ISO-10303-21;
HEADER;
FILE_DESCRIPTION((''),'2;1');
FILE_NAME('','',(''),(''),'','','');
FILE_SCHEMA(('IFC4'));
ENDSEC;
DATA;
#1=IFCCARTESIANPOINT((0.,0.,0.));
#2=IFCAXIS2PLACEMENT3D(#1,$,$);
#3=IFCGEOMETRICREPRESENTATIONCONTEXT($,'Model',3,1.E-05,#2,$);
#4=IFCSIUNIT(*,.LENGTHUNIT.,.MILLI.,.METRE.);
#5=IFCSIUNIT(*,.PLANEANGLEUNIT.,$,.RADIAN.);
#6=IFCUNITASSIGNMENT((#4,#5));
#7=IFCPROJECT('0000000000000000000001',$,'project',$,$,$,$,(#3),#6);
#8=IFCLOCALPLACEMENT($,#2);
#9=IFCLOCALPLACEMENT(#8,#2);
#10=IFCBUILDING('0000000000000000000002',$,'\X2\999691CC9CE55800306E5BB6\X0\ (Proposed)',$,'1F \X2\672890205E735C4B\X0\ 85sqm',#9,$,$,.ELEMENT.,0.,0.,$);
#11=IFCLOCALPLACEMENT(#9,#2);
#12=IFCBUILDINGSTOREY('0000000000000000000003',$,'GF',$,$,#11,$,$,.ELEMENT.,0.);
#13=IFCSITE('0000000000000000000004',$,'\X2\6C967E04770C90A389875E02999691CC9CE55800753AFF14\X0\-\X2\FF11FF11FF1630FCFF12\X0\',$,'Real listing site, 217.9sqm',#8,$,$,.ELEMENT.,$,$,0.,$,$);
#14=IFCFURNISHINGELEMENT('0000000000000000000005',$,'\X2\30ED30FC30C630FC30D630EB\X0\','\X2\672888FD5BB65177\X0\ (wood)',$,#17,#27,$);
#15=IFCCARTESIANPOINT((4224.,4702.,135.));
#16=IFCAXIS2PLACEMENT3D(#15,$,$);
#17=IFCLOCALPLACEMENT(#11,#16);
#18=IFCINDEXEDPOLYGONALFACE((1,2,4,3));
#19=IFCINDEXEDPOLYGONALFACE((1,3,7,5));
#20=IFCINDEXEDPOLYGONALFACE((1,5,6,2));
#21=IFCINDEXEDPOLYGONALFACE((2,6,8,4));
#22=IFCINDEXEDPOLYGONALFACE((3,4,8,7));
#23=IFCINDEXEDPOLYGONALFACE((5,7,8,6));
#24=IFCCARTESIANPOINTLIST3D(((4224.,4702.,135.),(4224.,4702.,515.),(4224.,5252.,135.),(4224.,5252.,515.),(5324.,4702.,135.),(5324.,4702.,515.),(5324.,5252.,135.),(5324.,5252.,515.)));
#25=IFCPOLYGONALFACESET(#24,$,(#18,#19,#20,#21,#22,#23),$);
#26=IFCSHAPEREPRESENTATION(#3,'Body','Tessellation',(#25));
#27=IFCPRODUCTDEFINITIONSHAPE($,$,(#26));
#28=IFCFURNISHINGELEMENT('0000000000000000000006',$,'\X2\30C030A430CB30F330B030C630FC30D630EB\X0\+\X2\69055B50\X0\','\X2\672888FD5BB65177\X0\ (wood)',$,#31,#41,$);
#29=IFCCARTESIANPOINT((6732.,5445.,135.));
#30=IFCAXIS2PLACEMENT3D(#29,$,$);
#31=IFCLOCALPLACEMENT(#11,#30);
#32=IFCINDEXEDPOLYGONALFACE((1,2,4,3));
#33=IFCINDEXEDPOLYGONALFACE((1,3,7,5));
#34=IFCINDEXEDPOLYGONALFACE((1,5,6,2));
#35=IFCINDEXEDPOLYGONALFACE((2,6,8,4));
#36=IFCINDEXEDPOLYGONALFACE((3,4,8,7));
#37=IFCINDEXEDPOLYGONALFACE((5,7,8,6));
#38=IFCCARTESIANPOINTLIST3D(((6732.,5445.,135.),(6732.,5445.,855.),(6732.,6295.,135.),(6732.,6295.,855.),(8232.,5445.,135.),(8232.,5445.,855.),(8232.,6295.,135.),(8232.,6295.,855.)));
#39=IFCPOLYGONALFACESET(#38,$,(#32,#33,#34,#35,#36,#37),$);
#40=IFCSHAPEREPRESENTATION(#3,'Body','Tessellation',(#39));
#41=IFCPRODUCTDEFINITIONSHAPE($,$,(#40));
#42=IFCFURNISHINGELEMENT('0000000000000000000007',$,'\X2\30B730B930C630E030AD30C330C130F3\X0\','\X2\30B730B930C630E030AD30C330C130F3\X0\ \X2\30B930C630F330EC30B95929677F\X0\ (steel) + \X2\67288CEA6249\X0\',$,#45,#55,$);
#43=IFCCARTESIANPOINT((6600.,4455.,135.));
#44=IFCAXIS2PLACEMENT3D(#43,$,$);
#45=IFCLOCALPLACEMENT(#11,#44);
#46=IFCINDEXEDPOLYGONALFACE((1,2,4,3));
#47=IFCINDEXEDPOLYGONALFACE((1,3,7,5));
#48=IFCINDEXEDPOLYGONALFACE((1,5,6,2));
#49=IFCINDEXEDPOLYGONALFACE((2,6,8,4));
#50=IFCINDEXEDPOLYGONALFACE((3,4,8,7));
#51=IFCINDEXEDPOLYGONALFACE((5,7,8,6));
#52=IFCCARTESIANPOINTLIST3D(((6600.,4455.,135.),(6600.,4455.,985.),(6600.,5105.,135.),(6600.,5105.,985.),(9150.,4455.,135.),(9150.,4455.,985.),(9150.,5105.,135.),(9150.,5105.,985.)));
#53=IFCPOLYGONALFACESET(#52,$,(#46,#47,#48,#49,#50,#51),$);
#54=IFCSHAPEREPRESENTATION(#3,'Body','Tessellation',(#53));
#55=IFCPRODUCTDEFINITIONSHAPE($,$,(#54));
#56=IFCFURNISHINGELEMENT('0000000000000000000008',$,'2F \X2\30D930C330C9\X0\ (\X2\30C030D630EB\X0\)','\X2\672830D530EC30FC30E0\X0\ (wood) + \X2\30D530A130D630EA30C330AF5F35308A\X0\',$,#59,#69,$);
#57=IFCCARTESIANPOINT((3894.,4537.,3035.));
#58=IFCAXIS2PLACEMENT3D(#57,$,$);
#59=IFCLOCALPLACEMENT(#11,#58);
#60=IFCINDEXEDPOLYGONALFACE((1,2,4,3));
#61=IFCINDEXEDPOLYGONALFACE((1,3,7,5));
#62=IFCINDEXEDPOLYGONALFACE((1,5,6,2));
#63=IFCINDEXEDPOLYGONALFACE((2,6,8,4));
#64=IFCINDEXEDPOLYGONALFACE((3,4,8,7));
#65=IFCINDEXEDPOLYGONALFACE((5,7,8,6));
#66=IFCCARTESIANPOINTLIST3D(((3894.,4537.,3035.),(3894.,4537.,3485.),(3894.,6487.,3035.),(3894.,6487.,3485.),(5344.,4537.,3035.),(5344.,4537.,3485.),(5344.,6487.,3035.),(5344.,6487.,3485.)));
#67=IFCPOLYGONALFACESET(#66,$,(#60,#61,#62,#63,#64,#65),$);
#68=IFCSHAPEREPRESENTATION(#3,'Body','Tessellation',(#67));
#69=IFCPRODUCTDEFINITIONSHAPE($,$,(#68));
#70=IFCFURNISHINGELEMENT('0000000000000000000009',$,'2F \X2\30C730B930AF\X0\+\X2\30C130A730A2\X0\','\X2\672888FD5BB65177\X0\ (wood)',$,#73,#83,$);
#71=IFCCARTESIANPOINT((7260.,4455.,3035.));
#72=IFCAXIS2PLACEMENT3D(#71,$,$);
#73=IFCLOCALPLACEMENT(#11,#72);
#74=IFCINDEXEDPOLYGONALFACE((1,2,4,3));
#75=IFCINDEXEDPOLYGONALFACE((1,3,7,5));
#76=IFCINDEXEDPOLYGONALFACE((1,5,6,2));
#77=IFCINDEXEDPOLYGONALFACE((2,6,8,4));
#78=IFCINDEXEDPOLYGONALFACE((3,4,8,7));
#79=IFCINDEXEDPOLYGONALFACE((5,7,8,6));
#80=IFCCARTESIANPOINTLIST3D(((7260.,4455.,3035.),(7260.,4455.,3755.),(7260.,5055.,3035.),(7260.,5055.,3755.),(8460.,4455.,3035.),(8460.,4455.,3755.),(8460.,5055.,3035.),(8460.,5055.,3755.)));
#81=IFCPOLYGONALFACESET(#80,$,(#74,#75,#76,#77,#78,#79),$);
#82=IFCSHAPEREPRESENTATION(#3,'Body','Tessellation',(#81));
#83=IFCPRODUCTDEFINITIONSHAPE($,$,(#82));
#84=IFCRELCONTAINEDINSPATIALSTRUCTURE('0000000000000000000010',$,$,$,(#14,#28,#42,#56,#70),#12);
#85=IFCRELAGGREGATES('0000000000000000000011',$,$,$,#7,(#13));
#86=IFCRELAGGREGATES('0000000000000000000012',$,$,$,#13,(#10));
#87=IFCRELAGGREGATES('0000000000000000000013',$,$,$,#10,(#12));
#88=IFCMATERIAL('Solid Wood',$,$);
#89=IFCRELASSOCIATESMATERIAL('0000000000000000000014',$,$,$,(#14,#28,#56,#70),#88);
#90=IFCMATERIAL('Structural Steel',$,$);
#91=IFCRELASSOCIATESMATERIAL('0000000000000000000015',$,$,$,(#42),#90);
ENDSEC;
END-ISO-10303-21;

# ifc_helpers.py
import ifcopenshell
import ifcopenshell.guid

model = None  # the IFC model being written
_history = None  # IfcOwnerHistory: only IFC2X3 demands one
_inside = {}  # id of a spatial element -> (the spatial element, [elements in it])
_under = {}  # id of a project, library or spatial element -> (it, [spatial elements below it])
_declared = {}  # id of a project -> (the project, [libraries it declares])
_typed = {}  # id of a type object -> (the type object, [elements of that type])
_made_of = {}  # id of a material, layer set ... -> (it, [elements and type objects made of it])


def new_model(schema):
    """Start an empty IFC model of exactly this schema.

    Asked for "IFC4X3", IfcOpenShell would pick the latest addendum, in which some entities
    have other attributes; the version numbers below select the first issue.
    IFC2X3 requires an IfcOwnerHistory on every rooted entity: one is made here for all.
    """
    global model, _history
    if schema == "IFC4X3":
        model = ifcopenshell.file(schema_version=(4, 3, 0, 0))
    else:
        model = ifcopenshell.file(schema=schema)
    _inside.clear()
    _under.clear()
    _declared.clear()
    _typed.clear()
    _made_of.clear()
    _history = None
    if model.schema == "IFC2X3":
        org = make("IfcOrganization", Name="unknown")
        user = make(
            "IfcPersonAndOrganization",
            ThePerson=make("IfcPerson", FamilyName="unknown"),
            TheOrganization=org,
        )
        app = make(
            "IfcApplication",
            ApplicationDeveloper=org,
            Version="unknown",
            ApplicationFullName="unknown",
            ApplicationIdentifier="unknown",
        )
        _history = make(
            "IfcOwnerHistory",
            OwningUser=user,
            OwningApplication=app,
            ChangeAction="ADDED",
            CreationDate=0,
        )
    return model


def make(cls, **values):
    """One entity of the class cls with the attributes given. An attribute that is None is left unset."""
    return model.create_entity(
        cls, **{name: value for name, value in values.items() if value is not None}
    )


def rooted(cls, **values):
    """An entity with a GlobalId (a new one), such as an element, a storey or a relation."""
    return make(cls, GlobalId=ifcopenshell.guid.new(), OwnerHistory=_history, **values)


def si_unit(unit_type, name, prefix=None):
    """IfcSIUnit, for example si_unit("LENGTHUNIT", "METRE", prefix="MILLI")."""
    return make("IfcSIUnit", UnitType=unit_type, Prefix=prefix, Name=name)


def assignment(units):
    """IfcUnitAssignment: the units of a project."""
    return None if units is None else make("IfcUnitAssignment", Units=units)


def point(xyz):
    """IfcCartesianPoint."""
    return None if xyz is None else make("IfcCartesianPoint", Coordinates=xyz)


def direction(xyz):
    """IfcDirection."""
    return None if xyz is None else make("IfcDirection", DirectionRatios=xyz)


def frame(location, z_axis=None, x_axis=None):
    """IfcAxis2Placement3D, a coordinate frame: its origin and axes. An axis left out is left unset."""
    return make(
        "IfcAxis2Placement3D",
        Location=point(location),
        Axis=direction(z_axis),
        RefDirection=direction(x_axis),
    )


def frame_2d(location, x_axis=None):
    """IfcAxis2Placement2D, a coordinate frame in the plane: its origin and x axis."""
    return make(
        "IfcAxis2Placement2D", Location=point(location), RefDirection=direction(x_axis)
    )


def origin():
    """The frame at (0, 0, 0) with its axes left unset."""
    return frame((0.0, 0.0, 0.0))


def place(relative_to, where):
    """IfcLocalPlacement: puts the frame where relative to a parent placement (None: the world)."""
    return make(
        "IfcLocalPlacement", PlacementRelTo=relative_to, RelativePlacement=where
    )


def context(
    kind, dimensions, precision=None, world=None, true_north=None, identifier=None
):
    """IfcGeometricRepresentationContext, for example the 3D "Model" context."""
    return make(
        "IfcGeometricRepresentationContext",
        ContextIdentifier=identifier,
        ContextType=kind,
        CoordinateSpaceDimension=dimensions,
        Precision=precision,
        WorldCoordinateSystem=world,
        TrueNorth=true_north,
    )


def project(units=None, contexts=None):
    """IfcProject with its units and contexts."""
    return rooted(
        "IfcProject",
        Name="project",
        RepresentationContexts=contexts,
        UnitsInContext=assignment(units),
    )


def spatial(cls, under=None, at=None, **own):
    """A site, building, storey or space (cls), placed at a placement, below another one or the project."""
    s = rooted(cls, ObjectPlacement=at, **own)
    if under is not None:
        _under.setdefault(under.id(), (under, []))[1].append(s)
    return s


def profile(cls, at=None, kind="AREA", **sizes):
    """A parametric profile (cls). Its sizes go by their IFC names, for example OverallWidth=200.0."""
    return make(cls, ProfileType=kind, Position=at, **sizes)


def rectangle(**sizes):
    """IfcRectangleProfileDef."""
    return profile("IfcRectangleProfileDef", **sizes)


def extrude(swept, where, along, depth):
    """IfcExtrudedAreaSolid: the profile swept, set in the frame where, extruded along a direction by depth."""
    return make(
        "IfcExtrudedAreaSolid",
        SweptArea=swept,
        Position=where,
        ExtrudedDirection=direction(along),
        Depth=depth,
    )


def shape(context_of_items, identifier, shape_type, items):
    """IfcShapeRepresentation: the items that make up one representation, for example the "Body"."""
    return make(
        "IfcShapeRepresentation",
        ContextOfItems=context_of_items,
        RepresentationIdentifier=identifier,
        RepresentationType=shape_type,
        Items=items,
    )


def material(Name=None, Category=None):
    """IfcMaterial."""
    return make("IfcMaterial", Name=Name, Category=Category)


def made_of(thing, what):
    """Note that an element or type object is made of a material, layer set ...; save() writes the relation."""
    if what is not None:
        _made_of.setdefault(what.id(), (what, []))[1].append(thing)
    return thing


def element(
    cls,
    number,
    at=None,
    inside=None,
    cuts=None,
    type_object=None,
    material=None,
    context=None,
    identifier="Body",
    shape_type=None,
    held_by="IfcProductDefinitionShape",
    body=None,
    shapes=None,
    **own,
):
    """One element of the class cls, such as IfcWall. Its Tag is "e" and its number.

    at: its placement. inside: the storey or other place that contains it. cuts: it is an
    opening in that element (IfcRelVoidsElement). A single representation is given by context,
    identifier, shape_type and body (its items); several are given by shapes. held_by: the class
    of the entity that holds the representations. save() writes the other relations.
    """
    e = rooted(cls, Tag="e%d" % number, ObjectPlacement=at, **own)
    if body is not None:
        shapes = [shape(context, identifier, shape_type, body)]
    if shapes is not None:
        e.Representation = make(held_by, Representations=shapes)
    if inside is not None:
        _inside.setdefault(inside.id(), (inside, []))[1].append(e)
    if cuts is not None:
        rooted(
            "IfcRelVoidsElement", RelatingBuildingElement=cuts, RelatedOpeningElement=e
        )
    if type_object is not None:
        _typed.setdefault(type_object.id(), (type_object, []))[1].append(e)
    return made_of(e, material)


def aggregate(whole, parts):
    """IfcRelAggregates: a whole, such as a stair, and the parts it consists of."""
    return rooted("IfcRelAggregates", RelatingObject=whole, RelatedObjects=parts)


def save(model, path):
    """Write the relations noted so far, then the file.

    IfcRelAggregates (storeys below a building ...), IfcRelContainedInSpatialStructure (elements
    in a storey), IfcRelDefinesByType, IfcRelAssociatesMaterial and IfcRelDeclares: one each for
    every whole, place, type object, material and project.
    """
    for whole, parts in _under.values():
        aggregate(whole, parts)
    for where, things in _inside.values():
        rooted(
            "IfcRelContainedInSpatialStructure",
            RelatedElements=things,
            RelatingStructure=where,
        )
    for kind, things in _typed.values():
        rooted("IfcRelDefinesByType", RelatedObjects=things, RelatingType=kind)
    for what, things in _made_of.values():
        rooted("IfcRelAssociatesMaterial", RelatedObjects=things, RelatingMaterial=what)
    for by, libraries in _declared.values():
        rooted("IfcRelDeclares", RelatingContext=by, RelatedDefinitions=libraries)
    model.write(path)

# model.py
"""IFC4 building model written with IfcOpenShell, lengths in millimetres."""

from ifc_helpers import new_model, si_unit, frame, frame_2d, origin, place, context, project, spatial, rectangle, extrude, material, element, save


model = new_model("IFC4")

# Units and contexts
model_context = context("Model", 3, precision=1e-05, world=origin())
ifc_project = project(units=[si_unit("LENGTHUNIT", "METRE", prefix="MILLI"), si_unit("PLANEANGLEUNIT", "RADIAN")], contexts=[model_context])

# Site, building, storey
site_placement = place(None, origin())
site = spatial("IfcSite", under=ifc_project, at=site_placement, Name="沖縄県那覇市首里鳥堀町４-１１６ー２", ObjectType="Real listing site, 217.9sqm", CompositionType="ELEMENT", RefElevation=0.0)
building_placement = place(site_placement, origin())
building = spatial("IfcBuilding", under=site, at=building_placement, Name="首里鳥堀の家 (Proposed)", ObjectType="1F 木造平屋 85sqm", CompositionType="ELEMENT", ElevationOfRefHeight=0.0, ElevationOfTerrain=0.0)
storey_placement = place(building_placement, origin())
storey = spatial("IfcBuildingStorey", under=building, at=storey_placement, Name="GF", CompositionType="ELEMENT", Elevation=0.0)

# Shared definitions
ifc_material_1 = material(Name="Solid Wood")

# Shared definitions
ifc_material_2 = material(Name="Structural Steel")

# Furnishing elements
furnishing_1_placement = place(storey_placement, frame((4224.0, 4702.0, 135.0)))
element("IfcFurnishingElement", 1, at=furnishing_1_placement, inside=storey, material=ifc_material_1, Name="ローテーブル", Description="木製家具 (wood)", context=model_context, shape_type="SweptSolid", body=[
    extrude(rectangle(XDim=1100.0, YDim=550.0, at=frame_2d((550.0, 275.0))), frame((4224.0, 4702.0, 135.0)), (0.0, 0.0, 1.0), 380.0),
])
furnishing_2_placement = place(storey_placement, frame((6732.0, 5445.0, 135.0)))
element("IfcFurnishingElement", 2, at=furnishing_2_placement, inside=storey, material=ifc_material_1, Name="ダイニングテーブル+椅子", Description="木製家具 (wood)", context=model_context, shape_type="SweptSolid", body=[
    extrude(rectangle(XDim=1500.0, YDim=850.0, at=frame_2d((750.0, 425.0))), frame((6732.0, 5445.0, 135.0)), (0.0, 0.0, 1.0), 720.0),
])
furnishing_3_placement = place(storey_placement, frame((6600.0, 4455.0, 135.0)))
element("IfcFurnishingElement", 3, at=furnishing_3_placement, inside=storey, material=ifc_material_2, Name="システムキッチン", Description="システムキッチン ステンレス天板 (steel) + 木質扉", context=model_context, shape_type="SweptSolid", body=[
    extrude(rectangle(XDim=2550.0, YDim=650.0, at=frame_2d((1275.0, 325.0))), frame((6600.0, 4455.0, 135.0)), (0.0, 0.0, 1.0), 850.0),
])
furnishing_4_placement = place(storey_placement, frame((3894.0, 4537.0, 3035.0)))
element("IfcFurnishingElement", 4, at=furnishing_4_placement, inside=storey, material=ifc_material_1, Name="2F ベッド (ダブル)", Description="木フレーム (wood) + ファブリック張り", context=model_context, shape_type="SweptSolid", body=[
    extrude(rectangle(XDim=1450.0, YDim=1950.0, at=frame_2d((725.0, 975.0))), frame((3894.0, 4537.0, 3035.0)), (0.0, 0.0, 1.0), 450.0),
])
furnishing_5_placement = place(storey_placement, frame((7260.0, 4455.0, 3035.0)))
element("IfcFurnishingElement", 5, at=furnishing_5_placement, inside=storey, material=ifc_material_1, Name="2F デスク+チェア", Description="木製家具 (wood)", context=model_context, shape_type="SweptSolid", body=[
    extrude(rectangle(XDim=1200.0, YDim=600.0, at=frame_2d((600.0, 300.0))), frame((7260.0, 4455.0, 3035.0)), (0.0, 0.0, 1.0), 720.0),
])

save(model, "model.ifc")
